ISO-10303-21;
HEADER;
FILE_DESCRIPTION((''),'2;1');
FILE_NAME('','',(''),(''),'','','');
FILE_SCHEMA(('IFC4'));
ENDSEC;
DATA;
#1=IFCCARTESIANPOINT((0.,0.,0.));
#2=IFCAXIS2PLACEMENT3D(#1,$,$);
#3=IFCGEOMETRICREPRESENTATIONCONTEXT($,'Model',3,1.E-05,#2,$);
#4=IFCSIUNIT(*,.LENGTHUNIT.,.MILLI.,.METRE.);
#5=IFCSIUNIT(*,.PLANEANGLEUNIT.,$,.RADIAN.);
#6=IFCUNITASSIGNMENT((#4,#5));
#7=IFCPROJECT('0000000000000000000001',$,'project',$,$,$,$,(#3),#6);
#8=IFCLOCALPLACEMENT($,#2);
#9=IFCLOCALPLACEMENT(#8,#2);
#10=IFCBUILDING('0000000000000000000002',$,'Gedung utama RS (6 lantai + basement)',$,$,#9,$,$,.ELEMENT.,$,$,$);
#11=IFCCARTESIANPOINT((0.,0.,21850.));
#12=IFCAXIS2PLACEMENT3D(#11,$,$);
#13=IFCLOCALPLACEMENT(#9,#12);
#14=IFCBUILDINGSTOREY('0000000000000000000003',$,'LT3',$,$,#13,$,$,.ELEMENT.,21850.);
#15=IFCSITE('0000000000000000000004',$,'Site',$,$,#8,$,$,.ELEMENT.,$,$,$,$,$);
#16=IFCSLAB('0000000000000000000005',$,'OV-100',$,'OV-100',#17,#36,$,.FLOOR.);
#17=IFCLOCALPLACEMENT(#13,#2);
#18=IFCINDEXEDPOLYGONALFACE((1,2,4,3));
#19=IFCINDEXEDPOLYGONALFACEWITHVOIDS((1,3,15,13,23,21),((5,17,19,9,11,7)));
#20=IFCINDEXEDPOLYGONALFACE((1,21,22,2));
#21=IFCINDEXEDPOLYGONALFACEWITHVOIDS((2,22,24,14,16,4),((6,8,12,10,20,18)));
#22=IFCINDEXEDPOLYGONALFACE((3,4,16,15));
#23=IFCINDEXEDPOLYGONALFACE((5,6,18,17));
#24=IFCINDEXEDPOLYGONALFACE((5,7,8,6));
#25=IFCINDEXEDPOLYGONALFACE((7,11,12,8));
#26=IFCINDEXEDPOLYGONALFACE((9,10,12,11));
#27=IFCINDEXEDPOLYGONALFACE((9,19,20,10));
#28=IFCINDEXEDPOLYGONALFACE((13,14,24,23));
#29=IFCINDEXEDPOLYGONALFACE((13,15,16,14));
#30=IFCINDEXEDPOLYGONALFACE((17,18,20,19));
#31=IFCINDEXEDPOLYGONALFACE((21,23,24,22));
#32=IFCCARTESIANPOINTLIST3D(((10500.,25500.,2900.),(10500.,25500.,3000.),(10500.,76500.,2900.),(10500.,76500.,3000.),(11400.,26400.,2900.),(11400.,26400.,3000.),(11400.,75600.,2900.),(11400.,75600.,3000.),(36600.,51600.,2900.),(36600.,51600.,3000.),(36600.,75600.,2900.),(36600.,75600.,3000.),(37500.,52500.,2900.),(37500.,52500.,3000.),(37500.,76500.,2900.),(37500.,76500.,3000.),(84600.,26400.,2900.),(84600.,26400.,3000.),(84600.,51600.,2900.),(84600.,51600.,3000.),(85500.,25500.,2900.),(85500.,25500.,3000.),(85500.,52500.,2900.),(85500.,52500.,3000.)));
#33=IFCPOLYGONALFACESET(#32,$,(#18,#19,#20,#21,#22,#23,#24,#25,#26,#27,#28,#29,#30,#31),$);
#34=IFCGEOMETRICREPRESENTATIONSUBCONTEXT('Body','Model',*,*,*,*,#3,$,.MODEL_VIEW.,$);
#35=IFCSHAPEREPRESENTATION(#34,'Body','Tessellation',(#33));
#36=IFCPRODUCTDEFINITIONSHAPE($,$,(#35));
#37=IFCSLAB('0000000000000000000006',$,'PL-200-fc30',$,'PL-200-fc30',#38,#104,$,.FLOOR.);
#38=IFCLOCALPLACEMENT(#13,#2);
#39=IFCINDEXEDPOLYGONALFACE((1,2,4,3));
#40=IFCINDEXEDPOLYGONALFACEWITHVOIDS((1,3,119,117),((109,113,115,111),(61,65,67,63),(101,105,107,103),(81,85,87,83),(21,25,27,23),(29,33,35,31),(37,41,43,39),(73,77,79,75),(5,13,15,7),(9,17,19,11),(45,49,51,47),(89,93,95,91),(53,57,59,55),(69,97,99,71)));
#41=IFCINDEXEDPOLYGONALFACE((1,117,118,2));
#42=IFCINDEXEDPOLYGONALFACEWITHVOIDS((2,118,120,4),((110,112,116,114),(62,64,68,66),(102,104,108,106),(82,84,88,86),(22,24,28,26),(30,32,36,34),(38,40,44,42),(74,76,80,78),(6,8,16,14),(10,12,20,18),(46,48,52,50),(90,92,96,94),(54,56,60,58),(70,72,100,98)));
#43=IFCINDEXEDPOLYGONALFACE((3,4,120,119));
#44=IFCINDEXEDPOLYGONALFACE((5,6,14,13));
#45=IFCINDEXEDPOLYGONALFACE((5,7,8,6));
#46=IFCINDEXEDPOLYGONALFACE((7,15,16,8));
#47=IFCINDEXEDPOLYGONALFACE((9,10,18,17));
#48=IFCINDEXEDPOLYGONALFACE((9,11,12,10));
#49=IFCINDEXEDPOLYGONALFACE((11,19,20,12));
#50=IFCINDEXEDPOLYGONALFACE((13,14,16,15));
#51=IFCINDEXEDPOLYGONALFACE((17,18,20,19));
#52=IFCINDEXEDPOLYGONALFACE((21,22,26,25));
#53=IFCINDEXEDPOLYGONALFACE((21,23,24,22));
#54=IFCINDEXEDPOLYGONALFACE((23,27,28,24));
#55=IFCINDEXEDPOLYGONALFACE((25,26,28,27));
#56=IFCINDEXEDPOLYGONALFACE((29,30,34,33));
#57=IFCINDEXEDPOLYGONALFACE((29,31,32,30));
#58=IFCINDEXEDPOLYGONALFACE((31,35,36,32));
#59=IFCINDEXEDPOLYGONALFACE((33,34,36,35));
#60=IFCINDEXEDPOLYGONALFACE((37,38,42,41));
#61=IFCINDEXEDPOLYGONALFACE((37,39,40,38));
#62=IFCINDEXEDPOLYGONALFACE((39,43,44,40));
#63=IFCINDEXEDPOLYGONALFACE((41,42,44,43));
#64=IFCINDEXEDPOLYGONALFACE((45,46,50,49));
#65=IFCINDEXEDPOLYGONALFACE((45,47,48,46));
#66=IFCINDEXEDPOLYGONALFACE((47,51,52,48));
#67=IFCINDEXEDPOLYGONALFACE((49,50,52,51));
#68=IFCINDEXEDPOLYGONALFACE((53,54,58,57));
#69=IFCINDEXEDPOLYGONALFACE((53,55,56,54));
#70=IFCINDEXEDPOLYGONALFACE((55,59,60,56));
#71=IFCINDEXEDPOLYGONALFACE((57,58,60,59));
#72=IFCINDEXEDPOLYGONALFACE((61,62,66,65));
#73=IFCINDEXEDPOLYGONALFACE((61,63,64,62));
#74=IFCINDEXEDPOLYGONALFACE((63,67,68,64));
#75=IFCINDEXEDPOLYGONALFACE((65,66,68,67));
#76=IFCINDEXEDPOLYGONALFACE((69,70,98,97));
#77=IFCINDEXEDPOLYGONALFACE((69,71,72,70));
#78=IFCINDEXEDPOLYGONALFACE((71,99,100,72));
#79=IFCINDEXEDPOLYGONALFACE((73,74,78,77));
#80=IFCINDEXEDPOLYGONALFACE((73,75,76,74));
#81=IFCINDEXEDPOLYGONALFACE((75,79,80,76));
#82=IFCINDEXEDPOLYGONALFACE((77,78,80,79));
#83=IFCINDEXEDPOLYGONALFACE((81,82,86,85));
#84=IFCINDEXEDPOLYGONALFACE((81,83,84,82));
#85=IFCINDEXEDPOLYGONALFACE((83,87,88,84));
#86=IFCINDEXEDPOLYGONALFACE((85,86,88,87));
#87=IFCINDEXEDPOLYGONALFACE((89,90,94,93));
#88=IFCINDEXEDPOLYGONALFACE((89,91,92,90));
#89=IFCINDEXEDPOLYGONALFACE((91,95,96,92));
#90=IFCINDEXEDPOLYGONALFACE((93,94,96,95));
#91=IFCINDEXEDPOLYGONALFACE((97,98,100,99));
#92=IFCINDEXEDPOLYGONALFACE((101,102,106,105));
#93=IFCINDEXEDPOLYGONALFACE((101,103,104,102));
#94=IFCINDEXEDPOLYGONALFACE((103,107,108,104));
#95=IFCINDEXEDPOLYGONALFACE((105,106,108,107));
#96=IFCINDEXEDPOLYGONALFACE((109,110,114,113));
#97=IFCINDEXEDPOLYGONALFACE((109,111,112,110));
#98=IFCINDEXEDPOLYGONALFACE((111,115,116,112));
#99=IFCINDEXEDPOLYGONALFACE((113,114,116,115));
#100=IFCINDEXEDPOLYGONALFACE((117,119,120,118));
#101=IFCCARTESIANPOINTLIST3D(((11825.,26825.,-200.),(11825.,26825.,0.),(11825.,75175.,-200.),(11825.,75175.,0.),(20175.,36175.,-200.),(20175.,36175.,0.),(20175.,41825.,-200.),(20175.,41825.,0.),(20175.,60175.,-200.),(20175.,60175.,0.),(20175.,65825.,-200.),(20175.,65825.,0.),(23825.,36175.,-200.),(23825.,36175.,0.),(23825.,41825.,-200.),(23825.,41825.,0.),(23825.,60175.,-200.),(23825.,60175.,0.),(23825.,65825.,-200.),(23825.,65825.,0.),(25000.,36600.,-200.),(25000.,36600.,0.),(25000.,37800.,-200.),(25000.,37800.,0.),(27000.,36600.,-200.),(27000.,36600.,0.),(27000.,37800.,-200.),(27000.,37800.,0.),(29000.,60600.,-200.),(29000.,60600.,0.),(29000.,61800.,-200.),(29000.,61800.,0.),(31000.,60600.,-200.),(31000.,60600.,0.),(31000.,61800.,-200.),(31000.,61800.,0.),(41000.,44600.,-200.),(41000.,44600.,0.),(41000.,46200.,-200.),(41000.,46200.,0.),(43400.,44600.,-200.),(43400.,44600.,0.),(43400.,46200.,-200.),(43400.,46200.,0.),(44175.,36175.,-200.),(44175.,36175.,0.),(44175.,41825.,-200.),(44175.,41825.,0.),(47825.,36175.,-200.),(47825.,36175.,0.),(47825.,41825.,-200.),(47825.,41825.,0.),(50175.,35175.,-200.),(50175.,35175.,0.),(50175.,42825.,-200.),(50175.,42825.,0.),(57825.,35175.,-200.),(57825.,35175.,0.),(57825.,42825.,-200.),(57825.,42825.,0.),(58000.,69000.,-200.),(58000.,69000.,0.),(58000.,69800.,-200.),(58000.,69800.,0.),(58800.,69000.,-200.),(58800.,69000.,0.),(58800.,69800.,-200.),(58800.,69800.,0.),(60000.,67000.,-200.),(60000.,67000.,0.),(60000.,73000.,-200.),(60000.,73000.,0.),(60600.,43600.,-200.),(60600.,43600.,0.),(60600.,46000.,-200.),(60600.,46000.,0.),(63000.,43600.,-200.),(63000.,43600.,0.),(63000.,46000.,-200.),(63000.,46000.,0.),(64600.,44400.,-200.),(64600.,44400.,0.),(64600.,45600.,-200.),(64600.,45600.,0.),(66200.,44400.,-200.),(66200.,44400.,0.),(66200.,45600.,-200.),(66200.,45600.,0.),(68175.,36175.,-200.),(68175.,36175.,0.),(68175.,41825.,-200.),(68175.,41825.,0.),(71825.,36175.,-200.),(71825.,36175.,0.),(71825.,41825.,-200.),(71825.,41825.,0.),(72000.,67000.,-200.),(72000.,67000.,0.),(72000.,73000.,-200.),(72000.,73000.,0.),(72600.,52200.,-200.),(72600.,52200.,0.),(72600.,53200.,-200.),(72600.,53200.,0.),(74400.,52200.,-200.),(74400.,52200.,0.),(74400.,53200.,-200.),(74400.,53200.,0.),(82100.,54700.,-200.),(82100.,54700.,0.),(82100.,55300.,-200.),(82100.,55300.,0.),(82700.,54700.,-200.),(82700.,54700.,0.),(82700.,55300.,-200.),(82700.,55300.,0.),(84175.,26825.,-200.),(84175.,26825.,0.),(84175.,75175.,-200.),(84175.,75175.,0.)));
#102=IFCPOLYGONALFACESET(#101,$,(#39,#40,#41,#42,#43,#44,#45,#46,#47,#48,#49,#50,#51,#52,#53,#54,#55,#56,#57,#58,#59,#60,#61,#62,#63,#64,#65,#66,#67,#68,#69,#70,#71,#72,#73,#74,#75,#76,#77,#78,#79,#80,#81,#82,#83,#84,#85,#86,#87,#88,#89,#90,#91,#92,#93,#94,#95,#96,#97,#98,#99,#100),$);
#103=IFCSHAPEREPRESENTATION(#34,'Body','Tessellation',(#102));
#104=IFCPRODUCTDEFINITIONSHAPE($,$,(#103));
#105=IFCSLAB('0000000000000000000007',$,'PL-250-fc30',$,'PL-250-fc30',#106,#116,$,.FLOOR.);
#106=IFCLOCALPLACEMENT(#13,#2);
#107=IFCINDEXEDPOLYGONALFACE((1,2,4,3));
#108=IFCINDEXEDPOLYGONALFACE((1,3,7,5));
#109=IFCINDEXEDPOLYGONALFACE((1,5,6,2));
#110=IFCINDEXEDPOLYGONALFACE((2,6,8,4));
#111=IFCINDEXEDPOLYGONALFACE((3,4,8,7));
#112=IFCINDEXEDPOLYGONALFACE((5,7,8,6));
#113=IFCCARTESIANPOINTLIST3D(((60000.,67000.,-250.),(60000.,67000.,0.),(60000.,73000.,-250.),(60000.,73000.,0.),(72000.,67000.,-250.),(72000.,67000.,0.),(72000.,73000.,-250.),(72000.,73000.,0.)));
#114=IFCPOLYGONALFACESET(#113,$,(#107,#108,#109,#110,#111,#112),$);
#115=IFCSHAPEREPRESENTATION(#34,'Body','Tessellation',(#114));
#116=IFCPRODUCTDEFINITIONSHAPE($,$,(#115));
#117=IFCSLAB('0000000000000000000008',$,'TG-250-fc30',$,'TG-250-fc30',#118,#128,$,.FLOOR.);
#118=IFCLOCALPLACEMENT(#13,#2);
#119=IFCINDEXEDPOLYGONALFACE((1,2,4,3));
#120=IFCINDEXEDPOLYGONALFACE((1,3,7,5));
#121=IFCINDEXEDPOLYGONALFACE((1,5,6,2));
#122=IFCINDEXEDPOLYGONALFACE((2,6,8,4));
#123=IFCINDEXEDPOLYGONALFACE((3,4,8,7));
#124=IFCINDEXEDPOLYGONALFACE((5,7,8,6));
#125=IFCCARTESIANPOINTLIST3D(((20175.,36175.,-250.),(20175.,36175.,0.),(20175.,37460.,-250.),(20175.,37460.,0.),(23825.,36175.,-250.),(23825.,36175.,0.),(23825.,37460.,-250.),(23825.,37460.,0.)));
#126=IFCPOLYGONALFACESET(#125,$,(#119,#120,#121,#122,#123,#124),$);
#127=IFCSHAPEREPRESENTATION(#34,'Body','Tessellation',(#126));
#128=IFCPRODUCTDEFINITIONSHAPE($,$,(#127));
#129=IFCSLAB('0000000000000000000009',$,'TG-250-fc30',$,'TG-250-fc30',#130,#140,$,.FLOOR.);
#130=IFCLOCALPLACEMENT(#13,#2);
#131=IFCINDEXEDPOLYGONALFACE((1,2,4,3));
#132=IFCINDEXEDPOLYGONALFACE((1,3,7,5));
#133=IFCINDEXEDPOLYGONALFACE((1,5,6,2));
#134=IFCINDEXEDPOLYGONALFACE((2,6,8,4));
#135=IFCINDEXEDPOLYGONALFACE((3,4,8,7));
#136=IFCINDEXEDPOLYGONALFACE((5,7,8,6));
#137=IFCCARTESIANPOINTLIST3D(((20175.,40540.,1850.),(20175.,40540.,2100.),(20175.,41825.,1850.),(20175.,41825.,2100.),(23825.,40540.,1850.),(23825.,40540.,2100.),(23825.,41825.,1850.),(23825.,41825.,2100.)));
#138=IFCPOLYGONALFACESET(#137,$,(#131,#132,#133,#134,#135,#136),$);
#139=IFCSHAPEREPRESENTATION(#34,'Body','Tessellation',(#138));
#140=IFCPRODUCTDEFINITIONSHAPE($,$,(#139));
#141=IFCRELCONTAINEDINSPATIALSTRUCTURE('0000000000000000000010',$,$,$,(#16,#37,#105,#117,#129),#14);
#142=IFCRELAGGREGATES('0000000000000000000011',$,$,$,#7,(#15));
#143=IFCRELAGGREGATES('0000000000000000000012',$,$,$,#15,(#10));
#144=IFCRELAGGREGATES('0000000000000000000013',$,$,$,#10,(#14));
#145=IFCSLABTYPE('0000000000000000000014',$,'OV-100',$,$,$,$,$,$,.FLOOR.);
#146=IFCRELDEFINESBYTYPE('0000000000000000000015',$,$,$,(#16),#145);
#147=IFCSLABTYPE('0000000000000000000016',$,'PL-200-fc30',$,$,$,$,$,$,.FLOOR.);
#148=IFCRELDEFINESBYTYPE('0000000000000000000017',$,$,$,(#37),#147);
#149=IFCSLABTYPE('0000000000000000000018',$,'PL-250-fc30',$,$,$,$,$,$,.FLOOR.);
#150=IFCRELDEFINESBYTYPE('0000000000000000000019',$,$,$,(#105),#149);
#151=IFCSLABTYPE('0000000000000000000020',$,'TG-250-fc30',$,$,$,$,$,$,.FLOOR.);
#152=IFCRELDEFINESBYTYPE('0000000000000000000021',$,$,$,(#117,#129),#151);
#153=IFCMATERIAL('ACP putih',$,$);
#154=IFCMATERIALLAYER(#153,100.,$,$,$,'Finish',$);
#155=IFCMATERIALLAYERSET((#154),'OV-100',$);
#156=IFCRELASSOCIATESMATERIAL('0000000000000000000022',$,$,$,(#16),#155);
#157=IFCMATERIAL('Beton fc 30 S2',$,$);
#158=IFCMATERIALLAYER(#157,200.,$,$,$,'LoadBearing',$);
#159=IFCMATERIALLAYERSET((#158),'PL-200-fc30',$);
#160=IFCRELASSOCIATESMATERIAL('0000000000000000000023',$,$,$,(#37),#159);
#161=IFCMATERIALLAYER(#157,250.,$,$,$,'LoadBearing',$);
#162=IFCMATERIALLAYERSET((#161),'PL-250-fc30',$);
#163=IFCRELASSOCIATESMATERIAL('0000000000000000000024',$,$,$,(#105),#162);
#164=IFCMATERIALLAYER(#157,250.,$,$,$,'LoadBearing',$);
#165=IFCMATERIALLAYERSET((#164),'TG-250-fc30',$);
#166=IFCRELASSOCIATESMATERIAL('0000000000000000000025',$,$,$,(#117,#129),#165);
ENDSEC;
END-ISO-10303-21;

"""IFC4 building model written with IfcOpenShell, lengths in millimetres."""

from ifc_helpers import new_model, si_unit, frame, origin, place, context, subcontext, project, spatial, polyline, outline, extrude, material, layer, layer_set, layer_usage, type_object, element, save


model = new_model("IFC4")

# Units and contexts
model_context = context("Model", 3, precision=1e-05, world=origin())
body_context = subcontext(model_context, "Body", "Model", "MODEL_VIEW")
ifc_project = project(units=[si_unit("LENGTHUNIT", "METRE", prefix="MILLI"), si_unit("PLANEANGLEUNIT", "RADIAN")], contexts=[model_context])

# Site, building, storey
site_placement = place(None, origin())
site = spatial("IfcSite", under=ifc_project, at=site_placement, Name="Site", CompositionType="ELEMENT")
building_placement = place(site_placement, origin())
building = spatial("IfcBuilding", under=site, at=building_placement, Name="Gedung utama RS (6 lantai + basement)", CompositionType="ELEMENT")
storey_placement = place(building_placement, frame((0.0, 0.0, 21850.0)))
storey = spatial("IfcBuildingStorey", under=building, at=storey_placement, Name="LT3", CompositionType="ELEMENT", Elevation=21850.0)

# Shared definitions
ifc_material_1 = material(Name="Beton fc 30 S2")

# Slab
ifc_material_2 = material(Name="ACP putih")
ifc_layer_1 = layer(ifc_material_2, 100.0, Category="Finish")
ifc_layer_set_1 = layer_set([ifc_layer_1], Name="OV-100")
ifc_layer_usage_1 = layer_usage(ifc_layer_set_1, "AXIS3", "NEGATIVE", 3000.0)
slab_type_1 = type_object("IfcSlabType", Name="OV-100", PredefinedType="FLOOR")
slab_1_placement = place(storey_placement, origin())
element("IfcSlab", 1, at=slab_1_placement, inside=storey, type_object=slab_type_1, material=ifc_layer_usage_1, Name="OV-100", ObjectType="OV-100", PredefinedType="FLOOR", context=body_context, shape_type="SweptSolid", body=[
    extrude(outline(polyline([(85500.0, 52500.0), (37500.0, 52500.0), (37500.0, 76500.0), (10500.0, 76500.0), (10500.0, 25500.0), (85500.0, 25500.0), (85500.0, 52500.0)]), holes=[polyline([(84600.0, 26400.0), (11400.0, 26400.0), (11400.0, 75600.0), (36600.0, 75600.0), (36600.0, 51600.0), (84600.0, 51600.0), (84600.0, 26400.0)])]), frame((0.0, 0.0, 2900.0)), (0.0, 0.0, 1.0), 100.0),
])

# Slab, openings
ifc_layer_2 = layer(ifc_material_1, 200.0, Category="LoadBearing")
ifc_layer_set_2 = layer_set([ifc_layer_2], Name="PL-200-fc30")
ifc_layer_usage_2 = layer_usage(ifc_layer_set_2, "AXIS3", "NEGATIVE", 0.0)
slab_type_2 = type_object("IfcSlabType", Name="PL-200-fc30", PredefinedType="FLOOR")
slab_2_placement = place(storey_placement, origin())
slab_2 = element("IfcSlab", 2, at=slab_2_placement, inside=storey, type_object=slab_type_2, material=ifc_layer_usage_2, Name="PL-200-fc30", ObjectType="PL-200-fc30", PredefinedType="FLOOR", context=body_context, shape_type="SweptSolid", body=[
    extrude(outline(polyline([(84175.0, 26825.0), (84175.0, 75175.0), (11825.0, 75175.0), (11825.0, 26825.0), (84175.0, 26825.0)]), holes=[polyline([(23825.0, 36175.0), (23825.0, 41825.0), (20175.0, 41825.0), (20175.0, 36175.0), (23825.0, 36175.0)]), polyline([(47825.0, 36175.0), (47825.0, 41825.0), (44175.0, 41825.0), (44175.0, 36175.0), (47825.0, 36175.0)]), polyline([(71825.0, 36175.0), (71825.0, 41825.0), (68175.0, 41825.0), (68175.0, 36175.0), (71825.0, 36175.0)]), polyline([(23825.0, 60175.0), (23825.0, 65825.0), (20175.0, 65825.0), (20175.0, 60175.0), (23825.0, 60175.0)]), polyline([(72000.0, 67000.0), (72000.0, 73000.0), (60000.0, 73000.0), (60000.0, 67000.0), (72000.0, 67000.0)])]), frame((0.0, 0.0, -200.0)), (0.0, 0.0, 1.0), 200.0),
])
opening_1_placement = place(slab_2_placement, frame((0.0, 0.0, -8900.0)))
element("IfcOpeningElement", 3, at=opening_1_placement, cuts=slab_2, PredefinedType="OPENING", context=body_context, shape_type="SweptSolid", body=[
    extrude(outline(polyline([(27000.0, 36600.0), (27000.0, 37800.0), (25000.0, 37800.0), (25000.0, 36600.0), (27000.0, 36600.0)])), origin(), (0.0, 0.0, 1.0), 25800.0),
])
opening_2_placement = place(slab_2_placement, frame((0.0, 0.0, -8900.0)))
element("IfcOpeningElement", 4, at=opening_2_placement, cuts=slab_2, PredefinedType="OPENING", context=body_context, shape_type="SweptSolid", body=[
    extrude(outline(polyline([(43400.0, 44600.0), (43400.0, 46200.0), (41000.0, 46200.0), (41000.0, 44600.0), (43400.0, 44600.0)])), origin(), (0.0, 0.0, 1.0), 25800.0),
])
opening_3_placement = place(slab_2_placement, frame((0.0, 0.0, -8900.0)))
element("IfcOpeningElement", 5, at=opening_3_placement, cuts=slab_2, PredefinedType="OPENING", context=body_context, shape_type="SweptSolid", body=[
    extrude(outline(polyline([(66200.0, 44400.0), (66200.0, 45600.0), (64600.0, 45600.0), (64600.0, 44400.0), (66200.0, 44400.0)])), origin(), (0.0, 0.0, 1.0), 25800.0),
])
opening_4_placement = place(slab_2_placement, frame((0.0, 0.0, -4400.0)))
element("IfcOpeningElement", 6, at=opening_4_placement, cuts=slab_2, PredefinedType="OPENING", context=body_context, shape_type="SweptSolid", body=[
    extrude(outline(polyline([(63000.0, 43600.0), (63000.0, 46000.0), (60600.0, 46000.0), (60600.0, 43600.0), (63000.0, 43600.0)])), origin(), (0.0, 0.0, 1.0), 4500.0),
])
opening_5_placement = place(slab_2_placement, frame((0.0, 0.0, -8900.0)))
element("IfcOpeningElement", 7, at=opening_5_placement, cuts=slab_2, PredefinedType="OPENING", context=body_context, shape_type="SweptSolid", body=[
    extrude(outline(polyline([(31000.0, 60600.0), (31000.0, 61800.0), (29000.0, 61800.0), (29000.0, 60600.0), (31000.0, 60600.0)])), origin(), (0.0, 0.0, 1.0), 13200.0),
])
opening_6_placement = place(slab_2_placement, frame((0.0, 0.0, -8900.0)))
element("IfcOpeningElement", 8, at=opening_6_placement, cuts=slab_2, PredefinedType="OPENING", context=body_context, shape_type="SweptSolid", body=[
    extrude(outline(polyline([(82700.0, 54700.0), (82700.0, 55300.0), (82100.0, 55300.0), (82100.0, 54700.0), (82700.0, 54700.0)])), origin(), (0.0, 0.0, 1.0), 9000.0),
])
opening_7_placement = place(slab_2_placement, frame((0.0, 0.0, -4400.0)))
element("IfcOpeningElement", 9, at=opening_7_placement, cuts=slab_2, PredefinedType="OPENING", context=body_context, shape_type="SweptSolid", body=[
    extrude(outline(polyline([(74400.0, 52200.0), (74400.0, 53200.0), (72600.0, 53200.0), (72600.0, 52200.0), (74400.0, 52200.0)])), origin(), (0.0, 0.0, 1.0), 4500.0),
])
opening_8_placement = place(slab_2_placement, frame((0.0, 0.0, -4400.0)))
element("IfcOpeningElement", 10, at=opening_8_placement, cuts=slab_2, PredefinedType="OPENING", context=body_context, shape_type="SweptSolid", body=[
    extrude(outline(polyline([(58800.0, 69000.0), (58800.0, 69800.0), (58000.0, 69800.0), (58000.0, 69000.0), (58800.0, 69000.0)])), origin(), (0.0, 0.0, 1.0), 4500.0),
])
opening_9_placement = place(slab_2_placement, frame((0.0, 0.0, -8900.0)))
element("IfcOpeningElement", 11, at=opening_9_placement, cuts=slab_2, PredefinedType="OPENING", context=body_context, shape_type="SweptSolid", body=[
    extrude(outline(polyline([(57825.0, 35175.0), (57825.0, 42825.0), (50175.0, 42825.0), (50175.0, 35175.0), (57825.0, 35175.0)])), origin(), (0.0, 0.0, 1.0), 21600.0),
])

# Slabs
ifc_layer_3 = layer(ifc_material_1, 250.0, Category="LoadBearing")
ifc_layer_set_3 = layer_set([ifc_layer_3], Name="PL-250-fc30")
ifc_layer_usage_3 = layer_usage(ifc_layer_set_3, "AXIS3", "NEGATIVE", 0.0)
slab_type_3 = type_object("IfcSlabType", Name="PL-250-fc30", PredefinedType="FLOOR")
slab_3_placement = place(storey_placement, origin())
element("IfcSlab", 12, at=slab_3_placement, inside=storey, type_object=slab_type_3, material=ifc_layer_usage_3, Name="PL-250-fc30", ObjectType="PL-250-fc30", PredefinedType="FLOOR", context=body_context, shape_type="SweptSolid", body=[
    extrude(outline(polyline([(72000.0, 67000.0), (72000.0, 73000.0), (60000.0, 73000.0), (60000.0, 67000.0), (72000.0, 67000.0)])), frame((0.0, 0.0, -250.0)), (0.0, 0.0, 1.0), 250.0),
])
ifc_layer_4 = layer(ifc_material_1, 250.0, Category="LoadBearing")
ifc_layer_set_4 = layer_set([ifc_layer_4], Name="TG-250-fc30")
ifc_layer_usage_4 = layer_usage(ifc_layer_set_4, "AXIS3", "NEGATIVE", 0.0)
slab_type_4 = type_object("IfcSlabType", Name="TG-250-fc30", PredefinedType="FLOOR")
slab_4_placement = place(storey_placement, origin())
element("IfcSlab", 13, at=slab_4_placement, inside=storey, type_object=slab_type_4, material=ifc_layer_usage_4, Name="TG-250-fc30", ObjectType="TG-250-fc30", PredefinedType="FLOOR", context=body_context, shape_type="SweptSolid", body=[
    extrude(outline(polyline([(23825.0, 36175.0), (23825.0, 37460.0), (20175.0, 37460.0), (20175.0, 36175.0), (23825.0, 36175.0)])), frame((0.0, 0.0, -250.0)), (0.0, 0.0, 1.0), 250.0),
])
ifc_layer_usage_5 = layer_usage(ifc_layer_set_4, "AXIS3", "NEGATIVE", 2100.0)
slab_5_placement = place(storey_placement, origin())
element("IfcSlab", 14, at=slab_5_placement, inside=storey, type_object=slab_type_4, material=ifc_layer_usage_5, Name="TG-250-fc30", ObjectType="TG-250-fc30", PredefinedType="FLOOR", context=body_context, shape_type="SweptSolid", body=[
    extrude(outline(polyline([(23825.0, 40540.0), (23825.0, 41825.0), (20175.0, 41825.0), (20175.0, 40540.0), (23825.0, 40540.0)])), frame((0.0, 0.0, 1850.0)), (0.0, 0.0, 1.0), 250.0),
])

save(model, "model.ifc")
